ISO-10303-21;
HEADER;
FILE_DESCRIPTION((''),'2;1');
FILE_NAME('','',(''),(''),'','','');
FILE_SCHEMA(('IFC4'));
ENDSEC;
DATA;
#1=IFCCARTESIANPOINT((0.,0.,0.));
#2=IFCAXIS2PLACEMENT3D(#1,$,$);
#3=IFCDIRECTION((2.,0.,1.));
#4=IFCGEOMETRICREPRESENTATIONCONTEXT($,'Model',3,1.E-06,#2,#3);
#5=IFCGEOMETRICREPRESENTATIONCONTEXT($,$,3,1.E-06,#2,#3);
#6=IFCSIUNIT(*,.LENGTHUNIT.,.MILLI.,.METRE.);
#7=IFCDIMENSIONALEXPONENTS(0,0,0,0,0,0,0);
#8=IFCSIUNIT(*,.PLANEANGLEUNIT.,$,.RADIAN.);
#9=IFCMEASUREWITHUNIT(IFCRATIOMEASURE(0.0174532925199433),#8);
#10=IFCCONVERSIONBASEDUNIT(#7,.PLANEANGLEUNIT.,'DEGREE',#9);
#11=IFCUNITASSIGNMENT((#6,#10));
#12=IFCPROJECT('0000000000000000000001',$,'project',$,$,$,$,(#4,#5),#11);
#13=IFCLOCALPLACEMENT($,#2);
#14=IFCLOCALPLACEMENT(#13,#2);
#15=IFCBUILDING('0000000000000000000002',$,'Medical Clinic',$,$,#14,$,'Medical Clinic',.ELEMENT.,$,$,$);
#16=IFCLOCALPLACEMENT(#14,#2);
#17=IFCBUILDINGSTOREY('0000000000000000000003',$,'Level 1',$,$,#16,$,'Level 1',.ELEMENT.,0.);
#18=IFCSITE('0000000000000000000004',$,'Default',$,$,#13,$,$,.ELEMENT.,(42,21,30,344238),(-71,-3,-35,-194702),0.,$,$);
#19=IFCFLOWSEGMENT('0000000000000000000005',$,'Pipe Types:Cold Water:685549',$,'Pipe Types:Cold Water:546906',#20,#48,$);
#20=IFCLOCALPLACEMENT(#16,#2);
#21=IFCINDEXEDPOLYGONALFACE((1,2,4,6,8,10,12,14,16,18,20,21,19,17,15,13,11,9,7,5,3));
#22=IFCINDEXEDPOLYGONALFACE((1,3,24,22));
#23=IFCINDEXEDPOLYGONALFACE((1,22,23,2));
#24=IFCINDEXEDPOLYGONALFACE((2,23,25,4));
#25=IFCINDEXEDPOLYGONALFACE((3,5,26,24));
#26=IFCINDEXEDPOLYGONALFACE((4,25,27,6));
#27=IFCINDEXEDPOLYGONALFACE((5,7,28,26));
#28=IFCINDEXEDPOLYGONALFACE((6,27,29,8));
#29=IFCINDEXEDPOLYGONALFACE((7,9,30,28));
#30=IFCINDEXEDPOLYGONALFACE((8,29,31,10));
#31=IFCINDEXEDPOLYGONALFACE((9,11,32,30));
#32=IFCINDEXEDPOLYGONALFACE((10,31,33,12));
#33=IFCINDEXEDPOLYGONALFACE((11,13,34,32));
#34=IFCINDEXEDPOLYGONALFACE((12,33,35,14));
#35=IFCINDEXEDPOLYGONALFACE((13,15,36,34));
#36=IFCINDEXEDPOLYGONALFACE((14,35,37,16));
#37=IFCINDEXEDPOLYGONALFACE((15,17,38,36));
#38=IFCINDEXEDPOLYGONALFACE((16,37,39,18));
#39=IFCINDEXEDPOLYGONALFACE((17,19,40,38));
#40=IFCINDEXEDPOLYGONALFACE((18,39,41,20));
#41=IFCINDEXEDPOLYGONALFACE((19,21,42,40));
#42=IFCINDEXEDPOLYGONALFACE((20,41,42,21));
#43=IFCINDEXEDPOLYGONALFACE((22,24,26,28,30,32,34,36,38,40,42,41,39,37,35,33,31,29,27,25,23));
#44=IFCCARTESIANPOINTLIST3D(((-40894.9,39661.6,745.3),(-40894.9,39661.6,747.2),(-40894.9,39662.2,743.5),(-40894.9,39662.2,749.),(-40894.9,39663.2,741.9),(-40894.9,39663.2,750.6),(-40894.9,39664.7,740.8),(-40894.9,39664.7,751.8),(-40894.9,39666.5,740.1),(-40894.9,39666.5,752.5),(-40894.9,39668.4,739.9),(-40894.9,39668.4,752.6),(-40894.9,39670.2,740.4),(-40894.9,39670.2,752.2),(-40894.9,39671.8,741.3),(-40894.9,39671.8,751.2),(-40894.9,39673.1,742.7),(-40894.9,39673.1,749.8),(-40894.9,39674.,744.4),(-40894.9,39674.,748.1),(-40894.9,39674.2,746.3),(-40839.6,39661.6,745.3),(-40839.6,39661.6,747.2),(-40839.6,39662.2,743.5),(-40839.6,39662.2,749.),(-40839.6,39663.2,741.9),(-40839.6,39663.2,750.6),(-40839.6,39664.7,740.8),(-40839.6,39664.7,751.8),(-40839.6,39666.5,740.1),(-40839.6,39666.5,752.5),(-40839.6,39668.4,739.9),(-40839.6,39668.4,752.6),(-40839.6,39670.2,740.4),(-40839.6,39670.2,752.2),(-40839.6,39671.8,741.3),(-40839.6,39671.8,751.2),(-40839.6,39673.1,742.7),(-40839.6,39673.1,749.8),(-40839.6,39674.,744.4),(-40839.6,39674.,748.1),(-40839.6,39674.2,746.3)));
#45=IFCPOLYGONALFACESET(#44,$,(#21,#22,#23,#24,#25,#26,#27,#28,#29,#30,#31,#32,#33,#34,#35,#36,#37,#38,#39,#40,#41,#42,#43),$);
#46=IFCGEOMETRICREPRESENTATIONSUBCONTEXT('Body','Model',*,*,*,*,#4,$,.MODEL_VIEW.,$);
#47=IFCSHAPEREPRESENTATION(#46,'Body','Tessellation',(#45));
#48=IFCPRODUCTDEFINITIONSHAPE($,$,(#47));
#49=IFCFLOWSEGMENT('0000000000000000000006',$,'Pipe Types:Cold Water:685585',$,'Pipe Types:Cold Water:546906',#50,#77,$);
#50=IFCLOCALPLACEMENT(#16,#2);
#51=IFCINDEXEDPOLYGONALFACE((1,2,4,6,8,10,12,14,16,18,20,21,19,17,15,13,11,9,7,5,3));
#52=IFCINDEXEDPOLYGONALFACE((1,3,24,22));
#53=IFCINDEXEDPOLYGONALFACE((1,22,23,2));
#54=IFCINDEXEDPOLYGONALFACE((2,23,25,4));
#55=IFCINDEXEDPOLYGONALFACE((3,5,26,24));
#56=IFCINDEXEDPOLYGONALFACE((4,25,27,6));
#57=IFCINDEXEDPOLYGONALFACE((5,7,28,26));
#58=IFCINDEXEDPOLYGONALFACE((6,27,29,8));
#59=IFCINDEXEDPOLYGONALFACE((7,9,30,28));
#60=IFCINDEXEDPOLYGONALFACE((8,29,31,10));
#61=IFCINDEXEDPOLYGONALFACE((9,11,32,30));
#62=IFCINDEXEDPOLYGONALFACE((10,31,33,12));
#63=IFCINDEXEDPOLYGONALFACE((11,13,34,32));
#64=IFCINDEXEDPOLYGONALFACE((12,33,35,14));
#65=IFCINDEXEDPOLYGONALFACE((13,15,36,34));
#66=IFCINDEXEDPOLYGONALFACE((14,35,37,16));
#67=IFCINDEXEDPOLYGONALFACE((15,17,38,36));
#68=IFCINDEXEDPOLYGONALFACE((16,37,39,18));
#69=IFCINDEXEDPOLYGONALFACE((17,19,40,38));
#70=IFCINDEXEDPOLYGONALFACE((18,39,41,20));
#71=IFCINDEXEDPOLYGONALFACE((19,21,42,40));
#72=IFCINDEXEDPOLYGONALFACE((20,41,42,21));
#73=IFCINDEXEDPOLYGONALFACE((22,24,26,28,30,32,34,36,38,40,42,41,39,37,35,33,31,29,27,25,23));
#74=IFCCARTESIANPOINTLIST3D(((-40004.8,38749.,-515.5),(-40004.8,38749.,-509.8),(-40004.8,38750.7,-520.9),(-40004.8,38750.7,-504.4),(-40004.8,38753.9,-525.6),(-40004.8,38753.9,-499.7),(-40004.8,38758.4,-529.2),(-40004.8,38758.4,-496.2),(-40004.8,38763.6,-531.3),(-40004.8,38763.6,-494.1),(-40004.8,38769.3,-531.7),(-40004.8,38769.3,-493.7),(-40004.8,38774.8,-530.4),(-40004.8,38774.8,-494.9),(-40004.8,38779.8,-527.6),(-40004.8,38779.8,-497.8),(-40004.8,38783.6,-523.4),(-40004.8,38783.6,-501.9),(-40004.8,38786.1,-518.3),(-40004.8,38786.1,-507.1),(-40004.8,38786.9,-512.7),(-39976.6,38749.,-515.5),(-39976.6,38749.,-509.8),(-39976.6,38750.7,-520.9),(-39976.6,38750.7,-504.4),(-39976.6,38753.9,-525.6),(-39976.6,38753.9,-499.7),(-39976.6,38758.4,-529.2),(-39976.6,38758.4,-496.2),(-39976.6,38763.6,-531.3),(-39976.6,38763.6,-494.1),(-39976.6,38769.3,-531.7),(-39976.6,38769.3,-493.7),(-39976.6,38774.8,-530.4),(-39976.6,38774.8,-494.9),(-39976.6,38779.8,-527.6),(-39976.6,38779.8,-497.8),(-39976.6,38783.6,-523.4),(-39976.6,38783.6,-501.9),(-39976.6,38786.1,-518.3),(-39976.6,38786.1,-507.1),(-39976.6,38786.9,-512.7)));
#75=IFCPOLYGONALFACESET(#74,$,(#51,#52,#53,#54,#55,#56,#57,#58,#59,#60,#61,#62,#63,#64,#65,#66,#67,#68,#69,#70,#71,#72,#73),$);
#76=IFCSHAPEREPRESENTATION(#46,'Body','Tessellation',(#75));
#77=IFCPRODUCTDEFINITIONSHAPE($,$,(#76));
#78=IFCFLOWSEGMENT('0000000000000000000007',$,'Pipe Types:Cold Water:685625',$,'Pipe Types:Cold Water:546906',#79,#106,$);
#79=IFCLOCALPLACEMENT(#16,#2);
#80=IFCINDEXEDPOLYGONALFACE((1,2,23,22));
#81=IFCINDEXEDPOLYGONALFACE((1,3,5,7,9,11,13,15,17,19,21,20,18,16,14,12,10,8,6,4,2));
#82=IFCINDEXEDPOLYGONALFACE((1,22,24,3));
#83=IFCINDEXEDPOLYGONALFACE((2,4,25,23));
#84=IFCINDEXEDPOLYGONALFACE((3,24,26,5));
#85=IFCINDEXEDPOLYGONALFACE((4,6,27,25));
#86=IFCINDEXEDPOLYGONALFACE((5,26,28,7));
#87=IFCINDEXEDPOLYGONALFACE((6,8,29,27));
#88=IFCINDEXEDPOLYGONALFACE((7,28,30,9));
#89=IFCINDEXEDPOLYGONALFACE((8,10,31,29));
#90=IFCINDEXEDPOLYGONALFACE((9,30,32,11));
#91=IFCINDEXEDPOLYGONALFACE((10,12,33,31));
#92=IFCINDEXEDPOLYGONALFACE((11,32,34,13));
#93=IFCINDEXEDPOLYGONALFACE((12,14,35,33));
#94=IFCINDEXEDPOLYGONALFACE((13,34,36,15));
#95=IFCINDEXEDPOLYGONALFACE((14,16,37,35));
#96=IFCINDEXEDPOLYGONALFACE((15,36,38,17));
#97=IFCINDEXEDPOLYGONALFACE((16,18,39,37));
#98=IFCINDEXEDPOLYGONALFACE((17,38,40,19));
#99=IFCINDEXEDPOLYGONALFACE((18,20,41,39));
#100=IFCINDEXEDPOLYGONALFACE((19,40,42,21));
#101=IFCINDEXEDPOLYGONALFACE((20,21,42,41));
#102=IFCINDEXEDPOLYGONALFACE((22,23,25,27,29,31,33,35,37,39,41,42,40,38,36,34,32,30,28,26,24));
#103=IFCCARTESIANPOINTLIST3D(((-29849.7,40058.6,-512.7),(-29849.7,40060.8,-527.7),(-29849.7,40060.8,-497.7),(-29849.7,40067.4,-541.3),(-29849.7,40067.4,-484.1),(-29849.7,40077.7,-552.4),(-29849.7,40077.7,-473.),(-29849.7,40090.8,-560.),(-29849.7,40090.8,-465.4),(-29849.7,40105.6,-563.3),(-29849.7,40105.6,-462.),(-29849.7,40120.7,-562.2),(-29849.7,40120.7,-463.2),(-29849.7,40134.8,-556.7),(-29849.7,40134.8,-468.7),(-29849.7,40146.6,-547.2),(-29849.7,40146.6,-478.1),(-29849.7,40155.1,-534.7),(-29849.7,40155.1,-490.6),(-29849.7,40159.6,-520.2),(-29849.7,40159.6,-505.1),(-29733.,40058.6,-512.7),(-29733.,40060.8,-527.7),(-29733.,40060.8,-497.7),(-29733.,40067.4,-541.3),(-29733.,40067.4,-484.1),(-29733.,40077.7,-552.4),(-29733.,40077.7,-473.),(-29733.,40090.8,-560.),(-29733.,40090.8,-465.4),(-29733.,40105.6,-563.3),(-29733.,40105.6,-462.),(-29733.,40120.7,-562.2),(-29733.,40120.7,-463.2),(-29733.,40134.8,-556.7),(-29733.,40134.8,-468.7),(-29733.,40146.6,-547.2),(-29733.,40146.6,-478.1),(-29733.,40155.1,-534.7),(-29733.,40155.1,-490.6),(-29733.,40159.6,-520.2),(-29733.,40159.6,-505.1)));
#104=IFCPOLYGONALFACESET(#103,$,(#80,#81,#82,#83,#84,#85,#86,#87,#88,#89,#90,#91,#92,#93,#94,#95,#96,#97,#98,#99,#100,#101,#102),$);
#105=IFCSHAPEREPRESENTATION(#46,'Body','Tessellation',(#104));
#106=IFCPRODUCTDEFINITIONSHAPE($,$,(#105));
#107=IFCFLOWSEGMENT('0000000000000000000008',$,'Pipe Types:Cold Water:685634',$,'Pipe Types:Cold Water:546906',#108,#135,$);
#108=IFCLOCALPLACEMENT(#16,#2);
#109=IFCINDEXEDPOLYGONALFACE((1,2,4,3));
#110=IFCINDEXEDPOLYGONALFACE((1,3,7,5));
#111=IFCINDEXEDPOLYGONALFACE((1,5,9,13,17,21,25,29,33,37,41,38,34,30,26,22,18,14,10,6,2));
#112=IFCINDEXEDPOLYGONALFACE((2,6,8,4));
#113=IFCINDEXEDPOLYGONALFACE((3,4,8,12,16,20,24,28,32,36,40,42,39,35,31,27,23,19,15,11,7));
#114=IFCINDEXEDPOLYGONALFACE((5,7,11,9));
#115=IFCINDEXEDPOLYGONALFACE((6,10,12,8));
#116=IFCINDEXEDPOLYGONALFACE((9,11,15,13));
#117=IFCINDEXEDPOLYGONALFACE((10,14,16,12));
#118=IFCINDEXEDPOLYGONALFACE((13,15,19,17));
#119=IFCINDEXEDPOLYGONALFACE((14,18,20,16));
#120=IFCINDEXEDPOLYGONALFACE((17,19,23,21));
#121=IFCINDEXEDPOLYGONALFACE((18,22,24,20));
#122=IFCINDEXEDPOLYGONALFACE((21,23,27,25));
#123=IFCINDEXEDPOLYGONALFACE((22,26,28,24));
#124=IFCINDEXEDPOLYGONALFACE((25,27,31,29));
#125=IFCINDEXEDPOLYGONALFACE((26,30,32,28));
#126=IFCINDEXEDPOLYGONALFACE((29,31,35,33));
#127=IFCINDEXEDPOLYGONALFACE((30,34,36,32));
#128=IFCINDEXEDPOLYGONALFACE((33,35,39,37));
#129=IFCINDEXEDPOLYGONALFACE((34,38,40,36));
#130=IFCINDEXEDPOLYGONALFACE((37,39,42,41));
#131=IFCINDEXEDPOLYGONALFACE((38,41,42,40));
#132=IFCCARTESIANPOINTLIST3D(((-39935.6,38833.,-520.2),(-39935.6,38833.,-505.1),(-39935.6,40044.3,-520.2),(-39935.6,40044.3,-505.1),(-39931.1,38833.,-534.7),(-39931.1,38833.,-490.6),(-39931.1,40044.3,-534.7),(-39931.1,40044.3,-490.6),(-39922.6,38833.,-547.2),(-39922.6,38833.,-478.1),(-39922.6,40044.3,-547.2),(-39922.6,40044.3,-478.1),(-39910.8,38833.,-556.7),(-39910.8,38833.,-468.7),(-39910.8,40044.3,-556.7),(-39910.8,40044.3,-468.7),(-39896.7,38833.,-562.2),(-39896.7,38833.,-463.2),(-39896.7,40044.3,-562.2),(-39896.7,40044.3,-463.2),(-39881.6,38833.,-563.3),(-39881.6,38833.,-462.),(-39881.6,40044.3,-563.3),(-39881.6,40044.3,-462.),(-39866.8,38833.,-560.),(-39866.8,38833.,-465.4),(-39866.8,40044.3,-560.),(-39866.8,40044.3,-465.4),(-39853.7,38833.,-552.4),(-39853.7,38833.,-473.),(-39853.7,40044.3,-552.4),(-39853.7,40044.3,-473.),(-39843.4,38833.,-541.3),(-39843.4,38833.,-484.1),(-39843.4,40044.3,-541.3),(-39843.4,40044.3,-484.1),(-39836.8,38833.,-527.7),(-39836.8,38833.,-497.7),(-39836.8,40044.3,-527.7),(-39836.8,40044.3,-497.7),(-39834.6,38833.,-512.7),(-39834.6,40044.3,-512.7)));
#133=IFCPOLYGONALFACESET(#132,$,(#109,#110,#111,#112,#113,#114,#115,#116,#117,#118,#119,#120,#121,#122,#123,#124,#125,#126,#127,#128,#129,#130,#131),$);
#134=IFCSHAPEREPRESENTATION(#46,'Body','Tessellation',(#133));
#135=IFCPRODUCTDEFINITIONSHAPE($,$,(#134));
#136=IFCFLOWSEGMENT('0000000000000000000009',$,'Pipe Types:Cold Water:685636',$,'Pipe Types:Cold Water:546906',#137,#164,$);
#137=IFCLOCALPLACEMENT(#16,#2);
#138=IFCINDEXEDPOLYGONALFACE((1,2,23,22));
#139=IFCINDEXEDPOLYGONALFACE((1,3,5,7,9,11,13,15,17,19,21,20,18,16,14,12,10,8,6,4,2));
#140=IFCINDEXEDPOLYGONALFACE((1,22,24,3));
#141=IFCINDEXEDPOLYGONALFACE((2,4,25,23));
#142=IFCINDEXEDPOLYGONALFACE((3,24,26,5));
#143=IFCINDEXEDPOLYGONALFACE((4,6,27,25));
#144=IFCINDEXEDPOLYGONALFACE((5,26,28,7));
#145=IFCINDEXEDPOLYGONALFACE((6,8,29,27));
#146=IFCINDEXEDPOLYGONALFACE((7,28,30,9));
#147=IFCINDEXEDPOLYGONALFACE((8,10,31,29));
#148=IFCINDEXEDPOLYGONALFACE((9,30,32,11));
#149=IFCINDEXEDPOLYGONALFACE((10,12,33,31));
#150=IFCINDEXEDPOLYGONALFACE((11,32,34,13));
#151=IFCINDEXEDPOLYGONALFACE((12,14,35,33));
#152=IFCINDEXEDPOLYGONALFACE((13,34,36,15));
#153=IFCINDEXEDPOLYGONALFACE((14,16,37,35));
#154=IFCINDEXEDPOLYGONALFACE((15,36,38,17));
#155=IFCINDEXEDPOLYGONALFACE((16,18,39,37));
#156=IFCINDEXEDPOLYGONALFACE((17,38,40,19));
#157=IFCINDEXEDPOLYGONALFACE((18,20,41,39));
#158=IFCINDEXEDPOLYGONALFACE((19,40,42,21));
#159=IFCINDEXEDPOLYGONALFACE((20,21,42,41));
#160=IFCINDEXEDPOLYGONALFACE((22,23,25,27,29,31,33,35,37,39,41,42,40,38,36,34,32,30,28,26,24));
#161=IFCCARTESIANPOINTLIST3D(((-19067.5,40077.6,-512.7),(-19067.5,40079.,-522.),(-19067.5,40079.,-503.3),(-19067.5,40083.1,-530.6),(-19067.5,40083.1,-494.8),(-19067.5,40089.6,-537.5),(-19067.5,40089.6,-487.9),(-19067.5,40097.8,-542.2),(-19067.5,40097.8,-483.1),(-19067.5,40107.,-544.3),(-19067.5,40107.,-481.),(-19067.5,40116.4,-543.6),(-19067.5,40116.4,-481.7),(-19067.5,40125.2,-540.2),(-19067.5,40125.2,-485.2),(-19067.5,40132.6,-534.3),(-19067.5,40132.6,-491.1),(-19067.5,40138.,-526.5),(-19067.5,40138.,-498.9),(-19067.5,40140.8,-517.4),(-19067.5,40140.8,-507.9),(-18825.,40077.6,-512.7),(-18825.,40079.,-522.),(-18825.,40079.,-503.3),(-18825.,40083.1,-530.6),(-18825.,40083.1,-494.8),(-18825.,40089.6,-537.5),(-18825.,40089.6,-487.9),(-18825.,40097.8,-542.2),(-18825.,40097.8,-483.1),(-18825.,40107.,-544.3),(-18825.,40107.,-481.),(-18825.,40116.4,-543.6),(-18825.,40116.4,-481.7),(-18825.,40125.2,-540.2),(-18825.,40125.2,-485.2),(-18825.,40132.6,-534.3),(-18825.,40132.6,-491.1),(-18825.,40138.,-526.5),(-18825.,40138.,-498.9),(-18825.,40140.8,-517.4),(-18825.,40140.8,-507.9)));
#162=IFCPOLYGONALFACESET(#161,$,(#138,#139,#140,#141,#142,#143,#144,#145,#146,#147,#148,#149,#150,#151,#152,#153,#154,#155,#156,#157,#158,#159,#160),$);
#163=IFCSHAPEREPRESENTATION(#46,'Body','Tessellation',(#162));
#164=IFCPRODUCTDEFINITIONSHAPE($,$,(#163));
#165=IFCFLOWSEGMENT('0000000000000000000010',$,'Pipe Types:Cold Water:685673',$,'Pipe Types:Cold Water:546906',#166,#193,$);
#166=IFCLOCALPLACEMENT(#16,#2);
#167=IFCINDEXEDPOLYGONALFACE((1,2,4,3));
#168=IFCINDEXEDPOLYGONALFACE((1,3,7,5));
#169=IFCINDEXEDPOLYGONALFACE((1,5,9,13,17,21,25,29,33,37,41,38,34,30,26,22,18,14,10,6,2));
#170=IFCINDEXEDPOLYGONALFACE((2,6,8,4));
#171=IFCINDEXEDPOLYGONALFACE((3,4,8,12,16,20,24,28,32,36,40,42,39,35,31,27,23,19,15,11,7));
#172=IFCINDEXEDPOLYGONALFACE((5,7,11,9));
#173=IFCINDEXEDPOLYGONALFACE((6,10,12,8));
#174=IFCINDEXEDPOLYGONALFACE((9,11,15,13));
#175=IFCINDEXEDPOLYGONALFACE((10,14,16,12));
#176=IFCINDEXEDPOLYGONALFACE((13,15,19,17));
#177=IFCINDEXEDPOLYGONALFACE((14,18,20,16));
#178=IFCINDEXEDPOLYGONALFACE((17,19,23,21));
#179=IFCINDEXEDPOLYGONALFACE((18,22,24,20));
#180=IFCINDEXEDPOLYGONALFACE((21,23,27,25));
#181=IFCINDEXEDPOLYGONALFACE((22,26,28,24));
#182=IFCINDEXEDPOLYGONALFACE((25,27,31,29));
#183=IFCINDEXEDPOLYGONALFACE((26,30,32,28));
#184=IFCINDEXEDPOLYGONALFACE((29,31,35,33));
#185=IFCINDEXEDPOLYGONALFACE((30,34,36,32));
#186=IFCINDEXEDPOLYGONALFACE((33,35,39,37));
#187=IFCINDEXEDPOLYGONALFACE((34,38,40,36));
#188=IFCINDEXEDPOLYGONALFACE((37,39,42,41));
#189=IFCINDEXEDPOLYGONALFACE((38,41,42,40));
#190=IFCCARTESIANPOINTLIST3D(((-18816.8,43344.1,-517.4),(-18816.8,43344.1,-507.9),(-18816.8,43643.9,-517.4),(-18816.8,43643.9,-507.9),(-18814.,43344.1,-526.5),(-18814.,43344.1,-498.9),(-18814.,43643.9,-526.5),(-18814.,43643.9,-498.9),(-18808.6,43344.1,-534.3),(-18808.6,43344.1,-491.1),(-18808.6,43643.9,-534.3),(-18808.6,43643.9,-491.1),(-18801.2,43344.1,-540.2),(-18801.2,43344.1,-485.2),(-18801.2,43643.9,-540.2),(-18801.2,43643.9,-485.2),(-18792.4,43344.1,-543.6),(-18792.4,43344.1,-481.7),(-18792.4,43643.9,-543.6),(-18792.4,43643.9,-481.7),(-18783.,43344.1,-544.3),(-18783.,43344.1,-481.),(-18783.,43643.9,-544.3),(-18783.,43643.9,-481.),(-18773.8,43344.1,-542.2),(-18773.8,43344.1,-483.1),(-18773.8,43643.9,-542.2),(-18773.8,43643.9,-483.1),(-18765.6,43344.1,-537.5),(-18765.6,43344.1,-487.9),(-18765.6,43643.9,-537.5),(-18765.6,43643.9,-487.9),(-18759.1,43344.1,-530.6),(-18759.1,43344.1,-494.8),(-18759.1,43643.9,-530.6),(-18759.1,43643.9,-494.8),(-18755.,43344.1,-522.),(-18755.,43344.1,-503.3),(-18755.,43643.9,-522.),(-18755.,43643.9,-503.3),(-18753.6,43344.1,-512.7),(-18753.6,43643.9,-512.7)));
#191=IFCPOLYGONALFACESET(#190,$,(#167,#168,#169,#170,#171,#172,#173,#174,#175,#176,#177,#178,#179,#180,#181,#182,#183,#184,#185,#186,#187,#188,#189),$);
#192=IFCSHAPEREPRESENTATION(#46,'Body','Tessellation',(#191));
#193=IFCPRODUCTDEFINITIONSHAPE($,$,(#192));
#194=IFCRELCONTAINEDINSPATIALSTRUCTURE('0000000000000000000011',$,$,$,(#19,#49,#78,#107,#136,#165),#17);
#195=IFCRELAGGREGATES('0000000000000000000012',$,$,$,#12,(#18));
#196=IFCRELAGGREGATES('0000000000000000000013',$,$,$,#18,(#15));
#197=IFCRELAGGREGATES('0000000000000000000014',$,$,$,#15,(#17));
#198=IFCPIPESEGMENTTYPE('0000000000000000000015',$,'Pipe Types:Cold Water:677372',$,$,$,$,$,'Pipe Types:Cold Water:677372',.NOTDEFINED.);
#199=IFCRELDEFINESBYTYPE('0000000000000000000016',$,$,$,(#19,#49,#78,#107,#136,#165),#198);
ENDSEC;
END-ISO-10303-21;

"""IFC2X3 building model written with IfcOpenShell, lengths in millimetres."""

from ifc_helpers import new_model, entity, si_unit, converted_unit, direction, frame, frame_2d, origin, origin_2d_with_axis, place, context, subcontext, project, spatial, circle, extrude, type_object, element, save


model = new_model("IFC2X3")

# Units and contexts
model_context = context("Model", 3, precision=1e-06, world=origin(), true_north=direction((2.0, 0.0, 1.0)))
context_of_model = context(None, 3, precision=1e-06, world=origin(), true_north=direction((2.0, 0.0, 1.0)))
body_context = subcontext(model_context, "Body", "Model", "MODEL_VIEW")
ifc_project = project(units=[si_unit("LENGTHUNIT", "METRE", prefix="MILLI"), converted_unit("PLANEANGLEUNIT", "DEGREE", entity("IfcRatioMeasure", 0.0174532925199433), si_unit("PLANEANGLEUNIT", "RADIAN"), dimensions=[0, 0, 0, 0, 0, 0, 0])], contexts=[model_context, context_of_model])

# Site, building, storey
site_placement = place(None, origin())
site = spatial("IfcSite", under=ifc_project, at=site_placement, Name="Default", CompositionType="ELEMENT", RefLatitude=(42, 21, 30, 344238), RefLongitude=(-71, -3, -35, -194702), RefElevation=0.0)
building_placement = place(site_placement, origin())
building = spatial("IfcBuilding", under=site, at=building_placement, Name="Medical Clinic", LongName="Medical Clinic", CompositionType="ELEMENT")
storey_placement = place(building_placement, origin())
storey = spatial("IfcBuildingStorey", under=building, at=storey_placement, Name="Level 1", LongName="Level 1", CompositionType="ELEMENT", Elevation=0.0)

# Flow segments
pipe_segment_type = type_object("IfcPipeSegmentType", Name="Pipe Types:Cold Water:677372", ElementType="Pipe Types:Cold Water:677372", PredefinedType="NOTDEFINED")
flow_segment_1_placement = place(storey_placement, origin())
element("IfcFlowSegment", 1, at=flow_segment_1_placement, inside=storey, type_object=pipe_segment_type, Name="Pipe Types:Cold Water:685549", ObjectType="Pipe Types:Cold Water:546906", context=body_context, shape_type="SweptSolid", body=[
    extrude(circle(Radius=6.3, at=frame_2d((0.0, 0.0), x_axis=(1.0, 0.0))), frame((-40894.9, 39667.9, 746.3), z_axis=(1.0, 0.0, 0.0), x_axis=(0.0, 1.0, 0.0)), (0.0, 0.0, 1.0), 55.3),
])
flow_segment_2_placement = place(storey_placement, origin())
element("IfcFlowSegment", 2, at=flow_segment_2_placement, inside=storey, type_object=pipe_segment_type, Name="Pipe Types:Cold Water:685585", ObjectType="Pipe Types:Cold Water:546906", context=body_context, shape_type="SweptSolid", body=[
    extrude(circle(Radius=19.1, at=frame_2d((0.0, 0.0), x_axis=(1.0, 0.0))), frame((-40004.8, 38767.9, -512.7), z_axis=(1.0, 0.0, 0.0), x_axis=(0.0, 1.0, 0.0)), (0.0, 0.0, 1.0), 28.2),
])
flow_segment_3_placement = place(storey_placement, origin())
element("IfcFlowSegment", 3, at=flow_segment_3_placement, inside=storey, type_object=pipe_segment_type, Name="Pipe Types:Cold Water:685625", ObjectType="Pipe Types:Cold Water:546906", context=body_context, shape_type="SweptSolid", body=[
    extrude(circle(Radius=50.8, at=frame_2d((0.0, 0.0), x_axis=(1.0, 0.0))), frame((-29849.7, 40109.4, -512.7), z_axis=(1.0, 0.0, 0.0), x_axis=(0.0, -1.0, 0.0)), (0.0, 0.0, 1.0), 116.8),
])
flow_segment_4_placement = place(storey_placement, origin())
element("IfcFlowSegment", 4, at=flow_segment_4_placement, inside=storey, type_object=pipe_segment_type, Name="Pipe Types:Cold Water:685634", ObjectType="Pipe Types:Cold Water:546906", context=body_context, shape_type="SweptSolid", body=[
    extrude(circle(Radius=50.8, at=frame_2d((0.0, 0.0), x_axis=(1.0, 0.0))), frame((-39885.4, 38833.0, -512.7), z_axis=(0.0, 1.0, 0.0), x_axis=(1.0, 0.0, 0.0)), (0.0, 0.0, 1.0), 1211.3),
])
flow_segment_5_placement = place(storey_placement, origin())
element("IfcFlowSegment", 5, at=flow_segment_5_placement, inside=storey, type_object=pipe_segment_type, Name="Pipe Types:Cold Water:685636", ObjectType="Pipe Types:Cold Water:546906", context=body_context, shape_type="SweptSolid", body=[
    extrude(circle(Radius=31.8, at=frame_2d((0.0, 0.0), x_axis=(1.0, 0.0))), frame((-19067.5, 40109.4, -512.7), z_axis=(1.0, 0.0, 0.0), x_axis=(0.0, -1.0, 0.0)), (0.0, 0.0, 1.0), 242.5),
])
flow_segment_6_placement = place(storey_placement, origin())
element("IfcFlowSegment", 6, at=flow_segment_6_placement, inside=storey, type_object=pipe_segment_type, Name="Pipe Types:Cold Water:685673", ObjectType="Pipe Types:Cold Water:546906", context=body_context, shape_type="SweptSolid", body=[
    extrude(circle(Radius=31.8, at=origin_2d_with_axis()), frame((-18785.4, 43344.1, -512.7), z_axis=(0.0, 1.0, 0.0), x_axis=(1.0, 0.0, 0.0)), (0.0, 0.0, 1.0), 299.8),
])

save(model, "model.ifc")
